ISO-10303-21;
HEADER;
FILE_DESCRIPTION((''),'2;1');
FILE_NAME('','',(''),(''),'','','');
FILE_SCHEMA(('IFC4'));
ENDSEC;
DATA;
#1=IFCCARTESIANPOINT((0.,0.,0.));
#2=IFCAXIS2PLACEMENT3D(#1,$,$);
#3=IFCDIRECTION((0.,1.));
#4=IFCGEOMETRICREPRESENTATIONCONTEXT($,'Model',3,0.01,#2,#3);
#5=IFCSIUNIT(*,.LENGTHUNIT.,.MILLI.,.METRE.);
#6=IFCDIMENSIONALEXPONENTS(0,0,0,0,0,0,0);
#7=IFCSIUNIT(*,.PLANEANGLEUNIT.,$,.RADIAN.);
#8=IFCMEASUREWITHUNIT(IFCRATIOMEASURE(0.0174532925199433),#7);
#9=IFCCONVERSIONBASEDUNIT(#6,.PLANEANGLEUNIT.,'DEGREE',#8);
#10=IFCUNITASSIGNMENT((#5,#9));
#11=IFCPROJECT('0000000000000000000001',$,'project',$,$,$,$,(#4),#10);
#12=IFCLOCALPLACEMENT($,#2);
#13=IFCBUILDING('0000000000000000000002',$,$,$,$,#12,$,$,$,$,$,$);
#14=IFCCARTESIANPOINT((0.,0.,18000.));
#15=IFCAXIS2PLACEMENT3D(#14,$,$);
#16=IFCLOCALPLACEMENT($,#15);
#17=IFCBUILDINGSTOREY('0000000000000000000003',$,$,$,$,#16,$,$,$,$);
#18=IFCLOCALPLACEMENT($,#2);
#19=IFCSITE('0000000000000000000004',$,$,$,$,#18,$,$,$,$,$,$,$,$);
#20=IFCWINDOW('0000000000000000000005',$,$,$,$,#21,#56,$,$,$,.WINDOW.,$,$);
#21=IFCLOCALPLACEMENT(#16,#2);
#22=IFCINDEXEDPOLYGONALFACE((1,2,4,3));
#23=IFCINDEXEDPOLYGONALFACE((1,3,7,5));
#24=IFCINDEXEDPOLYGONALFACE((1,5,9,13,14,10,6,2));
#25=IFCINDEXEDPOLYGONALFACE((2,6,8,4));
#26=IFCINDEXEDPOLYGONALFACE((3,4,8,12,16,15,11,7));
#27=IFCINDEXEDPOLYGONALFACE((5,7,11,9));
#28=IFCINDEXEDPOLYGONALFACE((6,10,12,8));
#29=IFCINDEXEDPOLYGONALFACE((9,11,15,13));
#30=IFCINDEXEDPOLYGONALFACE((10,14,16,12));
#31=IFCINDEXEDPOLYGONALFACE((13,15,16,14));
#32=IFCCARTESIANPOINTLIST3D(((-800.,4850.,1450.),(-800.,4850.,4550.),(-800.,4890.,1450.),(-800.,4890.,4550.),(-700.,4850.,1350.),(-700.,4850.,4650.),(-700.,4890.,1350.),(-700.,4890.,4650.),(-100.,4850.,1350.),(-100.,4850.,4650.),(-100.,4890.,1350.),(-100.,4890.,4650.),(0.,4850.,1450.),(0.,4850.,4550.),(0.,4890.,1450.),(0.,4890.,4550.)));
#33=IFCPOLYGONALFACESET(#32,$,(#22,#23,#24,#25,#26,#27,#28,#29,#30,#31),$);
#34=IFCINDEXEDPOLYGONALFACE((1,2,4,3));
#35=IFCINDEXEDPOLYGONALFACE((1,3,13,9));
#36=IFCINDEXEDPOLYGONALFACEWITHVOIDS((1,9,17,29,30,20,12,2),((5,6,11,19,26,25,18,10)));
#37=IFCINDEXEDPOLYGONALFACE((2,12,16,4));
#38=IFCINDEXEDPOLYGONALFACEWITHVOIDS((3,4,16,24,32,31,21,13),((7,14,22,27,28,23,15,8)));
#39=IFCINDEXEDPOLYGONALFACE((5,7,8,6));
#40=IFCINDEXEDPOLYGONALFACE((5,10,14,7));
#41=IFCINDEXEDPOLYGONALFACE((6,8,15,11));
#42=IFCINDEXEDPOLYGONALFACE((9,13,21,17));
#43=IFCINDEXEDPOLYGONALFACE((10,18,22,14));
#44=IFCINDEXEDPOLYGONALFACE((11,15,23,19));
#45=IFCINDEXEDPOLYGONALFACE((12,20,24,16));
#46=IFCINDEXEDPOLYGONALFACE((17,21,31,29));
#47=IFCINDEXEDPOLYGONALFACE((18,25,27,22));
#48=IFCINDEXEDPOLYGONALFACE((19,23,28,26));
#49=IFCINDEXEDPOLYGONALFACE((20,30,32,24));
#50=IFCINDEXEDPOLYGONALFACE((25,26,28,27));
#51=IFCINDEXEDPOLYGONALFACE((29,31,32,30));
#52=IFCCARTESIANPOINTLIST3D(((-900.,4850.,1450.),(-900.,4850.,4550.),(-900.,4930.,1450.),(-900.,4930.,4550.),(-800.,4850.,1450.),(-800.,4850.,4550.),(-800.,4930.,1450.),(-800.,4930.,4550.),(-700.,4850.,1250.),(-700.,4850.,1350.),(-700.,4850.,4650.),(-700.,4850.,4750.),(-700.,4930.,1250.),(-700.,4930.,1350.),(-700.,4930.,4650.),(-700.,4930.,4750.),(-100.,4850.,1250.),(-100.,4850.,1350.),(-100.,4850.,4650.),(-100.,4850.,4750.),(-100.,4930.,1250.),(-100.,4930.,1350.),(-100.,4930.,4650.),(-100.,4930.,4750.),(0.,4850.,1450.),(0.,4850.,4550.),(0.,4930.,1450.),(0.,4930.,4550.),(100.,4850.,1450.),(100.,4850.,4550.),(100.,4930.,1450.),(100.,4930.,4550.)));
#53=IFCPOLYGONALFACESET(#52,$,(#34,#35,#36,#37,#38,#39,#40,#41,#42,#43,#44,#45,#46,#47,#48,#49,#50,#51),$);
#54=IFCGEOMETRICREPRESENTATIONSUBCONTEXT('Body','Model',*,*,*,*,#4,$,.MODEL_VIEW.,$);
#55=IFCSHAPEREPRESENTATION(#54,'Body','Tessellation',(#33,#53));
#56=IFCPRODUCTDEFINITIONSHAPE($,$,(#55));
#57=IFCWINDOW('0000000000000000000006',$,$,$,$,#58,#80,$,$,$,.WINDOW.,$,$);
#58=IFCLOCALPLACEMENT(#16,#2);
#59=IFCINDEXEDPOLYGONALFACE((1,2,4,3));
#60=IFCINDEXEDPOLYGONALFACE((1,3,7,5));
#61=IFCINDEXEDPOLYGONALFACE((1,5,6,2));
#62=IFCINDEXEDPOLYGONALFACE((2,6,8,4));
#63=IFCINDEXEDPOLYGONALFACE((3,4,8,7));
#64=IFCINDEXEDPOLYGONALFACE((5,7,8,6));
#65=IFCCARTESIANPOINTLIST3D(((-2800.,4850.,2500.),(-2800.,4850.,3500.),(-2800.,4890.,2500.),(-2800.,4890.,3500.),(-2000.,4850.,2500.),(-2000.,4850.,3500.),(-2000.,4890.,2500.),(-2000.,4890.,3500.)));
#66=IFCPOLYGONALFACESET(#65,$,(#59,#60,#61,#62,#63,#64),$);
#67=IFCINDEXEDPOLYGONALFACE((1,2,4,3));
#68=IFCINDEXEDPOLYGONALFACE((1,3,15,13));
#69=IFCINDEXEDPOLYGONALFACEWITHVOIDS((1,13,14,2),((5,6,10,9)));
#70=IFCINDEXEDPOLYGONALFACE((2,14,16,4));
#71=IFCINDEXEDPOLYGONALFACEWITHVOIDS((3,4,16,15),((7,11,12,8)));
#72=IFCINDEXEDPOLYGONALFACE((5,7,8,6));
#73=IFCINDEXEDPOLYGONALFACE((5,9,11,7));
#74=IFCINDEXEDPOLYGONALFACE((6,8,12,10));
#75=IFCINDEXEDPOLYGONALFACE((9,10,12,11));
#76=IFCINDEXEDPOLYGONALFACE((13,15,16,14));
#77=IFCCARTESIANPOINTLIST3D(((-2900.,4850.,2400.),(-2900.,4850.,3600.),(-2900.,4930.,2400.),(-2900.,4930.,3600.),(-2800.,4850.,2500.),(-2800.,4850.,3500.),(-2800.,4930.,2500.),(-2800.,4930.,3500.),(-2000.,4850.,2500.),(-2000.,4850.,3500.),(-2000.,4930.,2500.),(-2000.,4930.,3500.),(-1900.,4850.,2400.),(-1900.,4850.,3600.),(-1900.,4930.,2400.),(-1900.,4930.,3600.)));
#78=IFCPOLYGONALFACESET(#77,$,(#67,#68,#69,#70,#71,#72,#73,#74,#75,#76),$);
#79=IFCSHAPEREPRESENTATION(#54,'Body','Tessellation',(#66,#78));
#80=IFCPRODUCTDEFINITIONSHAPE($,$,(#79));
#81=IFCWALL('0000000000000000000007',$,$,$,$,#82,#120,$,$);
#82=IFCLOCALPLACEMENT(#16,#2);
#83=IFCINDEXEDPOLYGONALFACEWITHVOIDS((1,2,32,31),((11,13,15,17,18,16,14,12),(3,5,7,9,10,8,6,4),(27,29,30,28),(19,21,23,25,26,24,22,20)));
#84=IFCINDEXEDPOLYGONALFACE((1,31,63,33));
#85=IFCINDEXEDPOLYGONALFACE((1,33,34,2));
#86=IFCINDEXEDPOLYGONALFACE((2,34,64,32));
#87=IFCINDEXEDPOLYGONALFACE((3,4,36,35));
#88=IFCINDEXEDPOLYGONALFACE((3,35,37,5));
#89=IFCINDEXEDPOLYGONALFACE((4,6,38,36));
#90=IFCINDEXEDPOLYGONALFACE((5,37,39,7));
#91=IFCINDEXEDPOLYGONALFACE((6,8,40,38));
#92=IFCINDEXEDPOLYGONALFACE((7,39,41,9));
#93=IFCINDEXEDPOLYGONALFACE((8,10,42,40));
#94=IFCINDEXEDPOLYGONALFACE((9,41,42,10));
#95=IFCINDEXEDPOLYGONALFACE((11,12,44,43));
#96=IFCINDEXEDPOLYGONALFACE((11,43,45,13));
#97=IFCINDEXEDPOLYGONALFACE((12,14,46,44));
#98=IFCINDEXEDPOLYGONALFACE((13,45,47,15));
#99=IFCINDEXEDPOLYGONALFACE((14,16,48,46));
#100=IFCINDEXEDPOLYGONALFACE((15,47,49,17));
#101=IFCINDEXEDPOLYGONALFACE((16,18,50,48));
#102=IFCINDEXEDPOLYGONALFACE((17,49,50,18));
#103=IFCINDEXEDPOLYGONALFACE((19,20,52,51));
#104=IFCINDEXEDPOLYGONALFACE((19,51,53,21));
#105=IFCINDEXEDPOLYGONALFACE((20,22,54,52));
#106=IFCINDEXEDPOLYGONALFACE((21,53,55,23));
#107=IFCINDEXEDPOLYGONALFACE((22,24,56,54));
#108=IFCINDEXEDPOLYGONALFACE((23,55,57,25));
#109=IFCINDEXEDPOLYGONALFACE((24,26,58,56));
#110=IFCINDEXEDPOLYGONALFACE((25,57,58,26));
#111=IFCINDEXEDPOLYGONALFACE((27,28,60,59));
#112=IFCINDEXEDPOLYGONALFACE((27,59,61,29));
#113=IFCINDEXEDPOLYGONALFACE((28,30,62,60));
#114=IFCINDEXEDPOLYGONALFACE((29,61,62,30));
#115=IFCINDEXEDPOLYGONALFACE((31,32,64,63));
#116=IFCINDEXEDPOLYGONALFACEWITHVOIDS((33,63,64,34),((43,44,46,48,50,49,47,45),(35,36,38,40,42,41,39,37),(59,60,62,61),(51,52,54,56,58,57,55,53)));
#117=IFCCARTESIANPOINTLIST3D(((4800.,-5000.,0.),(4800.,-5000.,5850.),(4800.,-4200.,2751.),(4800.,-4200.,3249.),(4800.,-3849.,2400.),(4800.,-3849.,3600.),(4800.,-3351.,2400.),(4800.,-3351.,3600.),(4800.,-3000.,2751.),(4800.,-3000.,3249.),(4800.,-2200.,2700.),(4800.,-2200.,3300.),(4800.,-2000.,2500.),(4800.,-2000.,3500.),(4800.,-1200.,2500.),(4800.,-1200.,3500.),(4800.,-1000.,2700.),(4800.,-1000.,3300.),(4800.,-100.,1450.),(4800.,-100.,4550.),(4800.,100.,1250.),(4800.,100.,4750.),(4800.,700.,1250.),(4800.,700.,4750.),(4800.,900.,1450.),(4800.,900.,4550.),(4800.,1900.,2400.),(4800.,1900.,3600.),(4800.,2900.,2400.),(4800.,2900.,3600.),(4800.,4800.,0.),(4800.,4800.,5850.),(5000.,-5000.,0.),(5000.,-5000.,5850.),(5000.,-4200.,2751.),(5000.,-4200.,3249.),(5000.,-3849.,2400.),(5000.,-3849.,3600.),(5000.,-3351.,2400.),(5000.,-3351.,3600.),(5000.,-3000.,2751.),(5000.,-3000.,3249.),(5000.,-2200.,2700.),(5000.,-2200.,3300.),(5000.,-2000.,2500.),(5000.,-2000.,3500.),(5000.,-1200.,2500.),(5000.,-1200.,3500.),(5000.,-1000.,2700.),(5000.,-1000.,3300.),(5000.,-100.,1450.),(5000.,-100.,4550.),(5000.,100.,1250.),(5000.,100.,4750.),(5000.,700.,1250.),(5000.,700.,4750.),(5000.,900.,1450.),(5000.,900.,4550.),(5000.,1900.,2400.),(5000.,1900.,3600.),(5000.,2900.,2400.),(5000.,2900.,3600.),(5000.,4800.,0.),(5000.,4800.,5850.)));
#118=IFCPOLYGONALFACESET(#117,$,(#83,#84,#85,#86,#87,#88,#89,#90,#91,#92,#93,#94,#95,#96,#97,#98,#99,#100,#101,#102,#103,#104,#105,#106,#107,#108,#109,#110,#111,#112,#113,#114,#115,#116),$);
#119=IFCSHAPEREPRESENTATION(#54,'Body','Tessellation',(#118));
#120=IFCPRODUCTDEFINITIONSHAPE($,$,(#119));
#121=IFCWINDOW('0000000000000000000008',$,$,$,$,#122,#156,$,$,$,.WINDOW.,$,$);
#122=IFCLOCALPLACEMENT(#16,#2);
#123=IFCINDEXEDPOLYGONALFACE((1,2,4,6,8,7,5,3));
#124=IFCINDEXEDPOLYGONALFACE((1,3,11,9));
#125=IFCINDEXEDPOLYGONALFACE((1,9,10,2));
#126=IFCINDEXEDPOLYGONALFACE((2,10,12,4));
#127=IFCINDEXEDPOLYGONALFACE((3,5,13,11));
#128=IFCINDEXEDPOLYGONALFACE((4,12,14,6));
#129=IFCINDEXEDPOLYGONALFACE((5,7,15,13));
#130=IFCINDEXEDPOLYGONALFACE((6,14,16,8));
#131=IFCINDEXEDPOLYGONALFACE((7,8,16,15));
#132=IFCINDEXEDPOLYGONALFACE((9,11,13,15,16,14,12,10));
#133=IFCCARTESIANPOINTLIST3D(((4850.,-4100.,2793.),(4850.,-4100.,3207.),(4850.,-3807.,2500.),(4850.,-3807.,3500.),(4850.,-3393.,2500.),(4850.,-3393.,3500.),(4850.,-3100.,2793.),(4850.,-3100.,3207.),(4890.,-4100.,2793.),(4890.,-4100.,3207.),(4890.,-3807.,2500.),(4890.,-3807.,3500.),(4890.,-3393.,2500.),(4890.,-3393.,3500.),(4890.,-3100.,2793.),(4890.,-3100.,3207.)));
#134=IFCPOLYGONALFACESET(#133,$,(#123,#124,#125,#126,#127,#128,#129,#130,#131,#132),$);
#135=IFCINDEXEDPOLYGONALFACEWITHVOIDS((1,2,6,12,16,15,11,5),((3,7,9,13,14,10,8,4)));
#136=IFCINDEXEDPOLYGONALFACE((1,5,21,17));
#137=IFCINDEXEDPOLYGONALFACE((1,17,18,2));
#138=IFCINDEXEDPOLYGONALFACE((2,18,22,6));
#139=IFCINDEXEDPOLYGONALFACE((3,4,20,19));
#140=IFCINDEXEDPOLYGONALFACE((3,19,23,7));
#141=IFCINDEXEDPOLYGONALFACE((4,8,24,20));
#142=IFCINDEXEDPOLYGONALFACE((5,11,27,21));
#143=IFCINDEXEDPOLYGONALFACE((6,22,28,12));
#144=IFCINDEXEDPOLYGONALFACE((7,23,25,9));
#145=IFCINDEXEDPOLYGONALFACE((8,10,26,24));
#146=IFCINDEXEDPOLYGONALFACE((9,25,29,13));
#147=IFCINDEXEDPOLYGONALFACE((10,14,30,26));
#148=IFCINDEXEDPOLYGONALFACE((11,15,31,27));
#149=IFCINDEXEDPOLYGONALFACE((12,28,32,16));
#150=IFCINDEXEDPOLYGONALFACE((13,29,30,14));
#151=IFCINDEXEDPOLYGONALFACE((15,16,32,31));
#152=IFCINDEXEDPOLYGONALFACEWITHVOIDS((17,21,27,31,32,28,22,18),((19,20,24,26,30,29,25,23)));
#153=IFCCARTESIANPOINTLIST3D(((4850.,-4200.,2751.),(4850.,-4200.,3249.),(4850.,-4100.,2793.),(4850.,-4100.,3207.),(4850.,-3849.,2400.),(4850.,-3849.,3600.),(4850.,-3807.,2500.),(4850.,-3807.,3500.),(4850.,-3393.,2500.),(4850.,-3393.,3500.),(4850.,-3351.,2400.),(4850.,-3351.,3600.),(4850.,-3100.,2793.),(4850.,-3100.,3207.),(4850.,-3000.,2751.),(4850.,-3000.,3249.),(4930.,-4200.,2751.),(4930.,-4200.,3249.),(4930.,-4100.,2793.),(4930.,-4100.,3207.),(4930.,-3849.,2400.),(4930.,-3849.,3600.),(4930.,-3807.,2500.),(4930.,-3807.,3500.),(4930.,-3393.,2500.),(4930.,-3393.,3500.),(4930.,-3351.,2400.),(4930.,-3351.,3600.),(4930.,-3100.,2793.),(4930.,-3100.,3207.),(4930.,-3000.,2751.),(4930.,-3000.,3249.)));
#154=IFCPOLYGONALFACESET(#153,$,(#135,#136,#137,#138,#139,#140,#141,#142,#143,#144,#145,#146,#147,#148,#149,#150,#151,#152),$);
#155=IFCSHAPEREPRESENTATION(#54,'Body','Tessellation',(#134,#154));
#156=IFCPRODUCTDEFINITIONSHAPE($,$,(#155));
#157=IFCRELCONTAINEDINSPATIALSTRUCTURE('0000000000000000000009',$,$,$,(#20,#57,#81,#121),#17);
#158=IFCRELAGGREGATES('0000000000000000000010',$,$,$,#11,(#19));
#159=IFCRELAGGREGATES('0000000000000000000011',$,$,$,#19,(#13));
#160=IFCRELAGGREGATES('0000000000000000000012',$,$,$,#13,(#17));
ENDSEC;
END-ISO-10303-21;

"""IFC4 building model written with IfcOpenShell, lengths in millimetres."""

from ifc_helpers import new_model, entity, si_unit, converted_unit, direction, frame, origin, origin_2d, place, context, subcontext, project, spatial, polyline, rectangle, outline, extrude, element, save


model = new_model("IFC4")

# Units and contexts
model_context = context("Model", 3, precision=0.01, world=origin(), true_north=direction((0.0, 1.0)))
body_context = subcontext(model_context, "Body", "Model", "MODEL_VIEW")
ifc_project = project(units=[si_unit("LENGTHUNIT", "METRE", prefix="MILLI"), converted_unit("PLANEANGLEUNIT", "DEGREE", entity("IfcRatioMeasure", 0.0174532925199433), si_unit("PLANEANGLEUNIT", "RADIAN"), dimensions=[0, 0, 0, 0, 0, 0, 0])], contexts=[model_context])

# Site, building, storey
site_placement = place(None, origin())
site = spatial("IfcSite", under=ifc_project, at=site_placement)
building_placement = place(None, origin())
building = spatial("IfcBuilding", under=site, at=building_placement)
storey_placement = place(None, frame((0.0, 0.0, 18000.0)))
storey = spatial("IfcBuildingStorey", under=building, at=storey_placement)

# Shared definitions
wall_1_placement = place(storey_placement, frame((100.0, 4900.0, 0.0), z_axis=(0.0, 0.0, 1.0), x_axis=(-1.0, 0.0, 0.0)))
window_1_placement = place(wall_1_placement, frame((500.0, 50.0, 3000.0)))
window_2_placement = place(wall_1_placement, frame((2500.0, 50.0, 3000.0)))

# Windows
cartesian_point_1 = entity("IfcCartesianPoint", [-500.0, -207.0])
shared_polyline_1 = entity("IfcPolyline", [cartesian_point_1, entity("IfcCartesianPoint", [-500.0, 207.0]), entity("IfcCartesianPoint", [-207.0, 500.0]), entity("IfcCartesianPoint", [207.0, 500.0]), entity("IfcCartesianPoint", [500.0, 207.0]), entity("IfcCartesianPoint", [500.0, -207.0]), entity("IfcCartesianPoint", [207.0, -500.0]), entity("IfcCartesianPoint", [-207.0, -500.0]), cartesian_point_1])
cartesian_point_2 = entity("IfcCartesianPoint", [-400.0, -1550.0])
shared_polyline_2 = entity("IfcPolyline", [cartesian_point_2, entity("IfcCartesianPoint", [-400.0, 1550.0]), entity("IfcCartesianPoint", [-300.0, 1650.0]), entity("IfcCartesianPoint", [300.0, 1650.0]), entity("IfcCartesianPoint", [400.0, 1550.0]), entity("IfcCartesianPoint", [400.0, -1550.0]), entity("IfcCartesianPoint", [300.0, -1650.0]), entity("IfcCartesianPoint", [-300.0, -1650.0]), cartesian_point_2])
cartesian_point_3 = entity("IfcCartesianPoint", [-500.0, -1550.0])
element("IfcWindow", 1, at=window_1_placement, inside=storey, PredefinedType="WINDOW", context=body_context, shape_type="SweptSolid", body=[
    entity("IfcExtrudedAreaSolid", entity("IfcArbitraryClosedProfileDef", "AREA", None, shared_polyline_2), entity("IfcAxis2Placement3D", entity("IfcCartesianPoint", [0.0, 0.0, 0.0]), entity("IfcDirection", [0.0, -1.0, 0.0]), entity("IfcDirection", [1.0, 0.0, 0.0])), entity("IfcDirection", [0.0, 0.0, 1.0]), 40.0),
    entity("IfcExtrudedAreaSolid", entity("IfcArbitraryProfileDefWithVoids", "AREA", None, entity("IfcPolyline", [cartesian_point_3, entity("IfcCartesianPoint", [-500.0, 1550.0]), entity("IfcCartesianPoint", [-300.0, 1750.0]), entity("IfcCartesianPoint", [300.0, 1750.0]), entity("IfcCartesianPoint", [500.0, 1550.0]), entity("IfcCartesianPoint", [500.0, -1550.0]), entity("IfcCartesianPoint", [300.0, -1750.0]), entity("IfcCartesianPoint", [-300.0, -1750.0]), cartesian_point_3]), [shared_polyline_2]), entity("IfcAxis2Placement3D", entity("IfcCartesianPoint", [0.0, 0.0, 0.0]), entity("IfcDirection", [0.0, -1.0, 0.0]), entity("IfcDirection", [1.0, 0.0, 0.0])), entity("IfcDirection", [0.0, 0.0, 1.0]), 80.0),
])
cartesian_point_4 = entity("IfcCartesianPoint", [-400.0, -500.0])
shared_polyline_3 = entity("IfcPolyline", [cartesian_point_4, entity("IfcCartesianPoint", [-400.0, 500.0]), entity("IfcCartesianPoint", [-400.0, 500.0]), entity("IfcCartesianPoint", [400.0, 500.0]), entity("IfcCartesianPoint", [400.0, 500.0]), entity("IfcCartesianPoint", [400.0, -500.0]), entity("IfcCartesianPoint", [400.0, -500.0]), entity("IfcCartesianPoint", [-400.0, -500.0]), cartesian_point_4])
cartesian_point_5 = entity("IfcCartesianPoint", [-500.0, -600.0])
element("IfcWindow", 2, at=window_2_placement, inside=storey, PredefinedType="WINDOW", context=body_context, shape_type="SweptSolid", body=[
    entity("IfcExtrudedAreaSolid", entity("IfcArbitraryClosedProfileDef", "AREA", None, shared_polyline_3), entity("IfcAxis2Placement3D", entity("IfcCartesianPoint", [0.0, 0.0, 0.0]), entity("IfcDirection", [0.0, -1.0, 0.0]), entity("IfcDirection", [1.0, 0.0, 0.0])), entity("IfcDirection", [0.0, 0.0, 1.0]), 40.0),
    entity("IfcExtrudedAreaSolid", entity("IfcArbitraryProfileDefWithVoids", "AREA", None, entity("IfcPolyline", [cartesian_point_5, entity("IfcCartesianPoint", [-500.0, 600.0]), entity("IfcCartesianPoint", [-500.0, 600.0]), entity("IfcCartesianPoint", [500.0, 600.0]), entity("IfcCartesianPoint", [500.0, 600.0]), entity("IfcCartesianPoint", [500.0, -600.0]), entity("IfcCartesianPoint", [500.0, -600.0]), entity("IfcCartesianPoint", [-500.0, -600.0]), cartesian_point_5]), [shared_polyline_3]), entity("IfcAxis2Placement3D", entity("IfcCartesianPoint", [0.0, 0.0, 0.0]), entity("IfcDirection", [0.0, -1.0, 0.0]), entity("IfcDirection", [1.0, 0.0, 0.0])), entity("IfcDirection", [0.0, 0.0, 1.0]), 80.0),
])

# Wall, openings
wall_2_placement = place(storey_placement, frame((4900.0, -100.0, 0.0), z_axis=(0.0, 0.0, 1.0), x_axis=(0.0, 1.0, 0.0)))
wall_2 = element("IfcWall", 3, at=wall_2_placement, inside=storey, context=body_context, shape_type="SweptSolid", body=[
    extrude(rectangle(XDim=9800.0, YDim=200.0, at=origin_2d()), origin(), (0.0, 0.0, 1.0), 5850.0),
])
window_3_placement = place(wall_2_placement, frame((-3500.0, 50.0, 3000.0)))
opening_1_placement = place(window_3_placement, frame((0.0, 50.0, 0.0)))
element("IfcOpeningElement", 4, at=opening_1_placement, cuts=wall_2, context=body_context, shape_type="SweptSolid", body=[
    extrude(outline(polyline([(-600.0, -249.0), (-600.0, 249.0), (-249.0, 600.0), (249.0, 600.0), (600.0, 249.0), (600.0, -249.0), (249.0, -600.0), (-249.0, -600.0), (-600.0, -249.0)])), frame((0.0, 0.0, 0.0), z_axis=(0.0, -1.0, 0.0), x_axis=(1.0, 0.0, 0.0)), (0.0, 0.0, 1.0), 200.0),
])
window_4_placement = place(wall_2_placement, frame((-1500.0, 50.0, 3000.0)))
opening_2_placement = place(window_4_placement, frame((0.0, 50.0, 0.0)))
element("IfcOpeningElement", 5, at=opening_2_placement, cuts=wall_2, context=body_context, shape_type="SweptSolid", body=[
    extrude(outline(polyline([(-600.0, -300.0), (-600.0, 300.0), (-400.0, 500.0), (400.0, 500.0), (600.0, 300.0), (600.0, -300.0), (400.0, -500.0), (-400.0, -500.0), (-600.0, -300.0)])), frame((0.0, 0.0, 0.0), z_axis=(0.0, -1.0, 0.0), x_axis=(1.0, 0.0, 0.0)), (0.0, 0.0, 1.0), 200.0),
])
window_5_placement = place(wall_2_placement, frame((500.0, 50.0, 3000.0)))
opening_3_placement = place(window_5_placement, frame((0.0, 50.0, 0.0)))
element("IfcOpeningElement", 6, at=opening_3_placement, cuts=wall_2, context=body_context, shape_type="SweptSolid", body=[
    extrude(outline(polyline([(-500.0, -1550.0), (-500.0, 1550.0), (-300.0, 1750.0), (300.0, 1750.0), (500.0, 1550.0), (500.0, -1550.0), (300.0, -1750.0), (-300.0, -1750.0), (-500.0, -1550.0)])), frame((0.0, 0.0, 0.0), z_axis=(0.0, -1.0, 0.0), x_axis=(1.0, 0.0, 0.0)), (0.0, 0.0, 1.0), 200.0),
])
window_6_placement = place(wall_2_placement, frame((2500.0, 50.0, 3000.0)))
opening_4_placement = place(window_6_placement, frame((0.0, 50.0, 0.0)))
element("IfcOpeningElement", 7, at=opening_4_placement, cuts=wall_2, context=body_context, shape_type="SweptSolid", body=[
    extrude(outline(polyline([(-500.0, -600.0), (-500.0, 600.0), (-500.0, 600.0), (500.0, 600.0), (500.0, 600.0), (500.0, -600.0), (500.0, -600.0), (-500.0, -600.0), (-500.0, -600.0)])), frame((0.0, 0.0, 0.0), z_axis=(0.0, -1.0, 0.0), x_axis=(1.0, 0.0, 0.0)), (0.0, 0.0, 1.0), 200.0),
])

# Window
cartesian_point_6 = entity("IfcCartesianPoint", [-600.0, -249.0])
element("IfcWindow", 8, at=window_3_placement, inside=storey, PredefinedType="WINDOW", context=body_context, shape_type="SweptSolid", body=[
    entity("IfcExtrudedAreaSolid", entity("IfcArbitraryClosedProfileDef", "AREA", None, shared_polyline_1), entity("IfcAxis2Placement3D", entity("IfcCartesianPoint", [0.0, 0.0, 0.0]), entity("IfcDirection", [0.0, -1.0, 0.0]), entity("IfcDirection", [1.0, 0.0, 0.0])), entity("IfcDirection", [0.0, 0.0, 1.0]), 40.0),
    entity("IfcExtrudedAreaSolid", entity("IfcArbitraryProfileDefWithVoids", "AREA", None, entity("IfcPolyline", [cartesian_point_6, entity("IfcCartesianPoint", [-600.0, 249.0]), entity("IfcCartesianPoint", [-249.0, 600.0]), entity("IfcCartesianPoint", [249.0, 600.0]), entity("IfcCartesianPoint", [600.0, 249.0]), entity("IfcCartesianPoint", [600.0, -249.0]), entity("IfcCartesianPoint", [249.0, -600.0]), entity("IfcCartesianPoint", [-249.0, -600.0]), cartesian_point_6]), [shared_polyline_1]), entity("IfcAxis2Placement3D", entity("IfcCartesianPoint", [0.0, 0.0, 0.0]), entity("IfcDirection", [0.0, -1.0, 0.0]), entity("IfcDirection", [1.0, 0.0, 0.0])), entity("IfcDirection", [0.0, 0.0, 1.0]), 80.0),
])

save(model, "model.ifc")
